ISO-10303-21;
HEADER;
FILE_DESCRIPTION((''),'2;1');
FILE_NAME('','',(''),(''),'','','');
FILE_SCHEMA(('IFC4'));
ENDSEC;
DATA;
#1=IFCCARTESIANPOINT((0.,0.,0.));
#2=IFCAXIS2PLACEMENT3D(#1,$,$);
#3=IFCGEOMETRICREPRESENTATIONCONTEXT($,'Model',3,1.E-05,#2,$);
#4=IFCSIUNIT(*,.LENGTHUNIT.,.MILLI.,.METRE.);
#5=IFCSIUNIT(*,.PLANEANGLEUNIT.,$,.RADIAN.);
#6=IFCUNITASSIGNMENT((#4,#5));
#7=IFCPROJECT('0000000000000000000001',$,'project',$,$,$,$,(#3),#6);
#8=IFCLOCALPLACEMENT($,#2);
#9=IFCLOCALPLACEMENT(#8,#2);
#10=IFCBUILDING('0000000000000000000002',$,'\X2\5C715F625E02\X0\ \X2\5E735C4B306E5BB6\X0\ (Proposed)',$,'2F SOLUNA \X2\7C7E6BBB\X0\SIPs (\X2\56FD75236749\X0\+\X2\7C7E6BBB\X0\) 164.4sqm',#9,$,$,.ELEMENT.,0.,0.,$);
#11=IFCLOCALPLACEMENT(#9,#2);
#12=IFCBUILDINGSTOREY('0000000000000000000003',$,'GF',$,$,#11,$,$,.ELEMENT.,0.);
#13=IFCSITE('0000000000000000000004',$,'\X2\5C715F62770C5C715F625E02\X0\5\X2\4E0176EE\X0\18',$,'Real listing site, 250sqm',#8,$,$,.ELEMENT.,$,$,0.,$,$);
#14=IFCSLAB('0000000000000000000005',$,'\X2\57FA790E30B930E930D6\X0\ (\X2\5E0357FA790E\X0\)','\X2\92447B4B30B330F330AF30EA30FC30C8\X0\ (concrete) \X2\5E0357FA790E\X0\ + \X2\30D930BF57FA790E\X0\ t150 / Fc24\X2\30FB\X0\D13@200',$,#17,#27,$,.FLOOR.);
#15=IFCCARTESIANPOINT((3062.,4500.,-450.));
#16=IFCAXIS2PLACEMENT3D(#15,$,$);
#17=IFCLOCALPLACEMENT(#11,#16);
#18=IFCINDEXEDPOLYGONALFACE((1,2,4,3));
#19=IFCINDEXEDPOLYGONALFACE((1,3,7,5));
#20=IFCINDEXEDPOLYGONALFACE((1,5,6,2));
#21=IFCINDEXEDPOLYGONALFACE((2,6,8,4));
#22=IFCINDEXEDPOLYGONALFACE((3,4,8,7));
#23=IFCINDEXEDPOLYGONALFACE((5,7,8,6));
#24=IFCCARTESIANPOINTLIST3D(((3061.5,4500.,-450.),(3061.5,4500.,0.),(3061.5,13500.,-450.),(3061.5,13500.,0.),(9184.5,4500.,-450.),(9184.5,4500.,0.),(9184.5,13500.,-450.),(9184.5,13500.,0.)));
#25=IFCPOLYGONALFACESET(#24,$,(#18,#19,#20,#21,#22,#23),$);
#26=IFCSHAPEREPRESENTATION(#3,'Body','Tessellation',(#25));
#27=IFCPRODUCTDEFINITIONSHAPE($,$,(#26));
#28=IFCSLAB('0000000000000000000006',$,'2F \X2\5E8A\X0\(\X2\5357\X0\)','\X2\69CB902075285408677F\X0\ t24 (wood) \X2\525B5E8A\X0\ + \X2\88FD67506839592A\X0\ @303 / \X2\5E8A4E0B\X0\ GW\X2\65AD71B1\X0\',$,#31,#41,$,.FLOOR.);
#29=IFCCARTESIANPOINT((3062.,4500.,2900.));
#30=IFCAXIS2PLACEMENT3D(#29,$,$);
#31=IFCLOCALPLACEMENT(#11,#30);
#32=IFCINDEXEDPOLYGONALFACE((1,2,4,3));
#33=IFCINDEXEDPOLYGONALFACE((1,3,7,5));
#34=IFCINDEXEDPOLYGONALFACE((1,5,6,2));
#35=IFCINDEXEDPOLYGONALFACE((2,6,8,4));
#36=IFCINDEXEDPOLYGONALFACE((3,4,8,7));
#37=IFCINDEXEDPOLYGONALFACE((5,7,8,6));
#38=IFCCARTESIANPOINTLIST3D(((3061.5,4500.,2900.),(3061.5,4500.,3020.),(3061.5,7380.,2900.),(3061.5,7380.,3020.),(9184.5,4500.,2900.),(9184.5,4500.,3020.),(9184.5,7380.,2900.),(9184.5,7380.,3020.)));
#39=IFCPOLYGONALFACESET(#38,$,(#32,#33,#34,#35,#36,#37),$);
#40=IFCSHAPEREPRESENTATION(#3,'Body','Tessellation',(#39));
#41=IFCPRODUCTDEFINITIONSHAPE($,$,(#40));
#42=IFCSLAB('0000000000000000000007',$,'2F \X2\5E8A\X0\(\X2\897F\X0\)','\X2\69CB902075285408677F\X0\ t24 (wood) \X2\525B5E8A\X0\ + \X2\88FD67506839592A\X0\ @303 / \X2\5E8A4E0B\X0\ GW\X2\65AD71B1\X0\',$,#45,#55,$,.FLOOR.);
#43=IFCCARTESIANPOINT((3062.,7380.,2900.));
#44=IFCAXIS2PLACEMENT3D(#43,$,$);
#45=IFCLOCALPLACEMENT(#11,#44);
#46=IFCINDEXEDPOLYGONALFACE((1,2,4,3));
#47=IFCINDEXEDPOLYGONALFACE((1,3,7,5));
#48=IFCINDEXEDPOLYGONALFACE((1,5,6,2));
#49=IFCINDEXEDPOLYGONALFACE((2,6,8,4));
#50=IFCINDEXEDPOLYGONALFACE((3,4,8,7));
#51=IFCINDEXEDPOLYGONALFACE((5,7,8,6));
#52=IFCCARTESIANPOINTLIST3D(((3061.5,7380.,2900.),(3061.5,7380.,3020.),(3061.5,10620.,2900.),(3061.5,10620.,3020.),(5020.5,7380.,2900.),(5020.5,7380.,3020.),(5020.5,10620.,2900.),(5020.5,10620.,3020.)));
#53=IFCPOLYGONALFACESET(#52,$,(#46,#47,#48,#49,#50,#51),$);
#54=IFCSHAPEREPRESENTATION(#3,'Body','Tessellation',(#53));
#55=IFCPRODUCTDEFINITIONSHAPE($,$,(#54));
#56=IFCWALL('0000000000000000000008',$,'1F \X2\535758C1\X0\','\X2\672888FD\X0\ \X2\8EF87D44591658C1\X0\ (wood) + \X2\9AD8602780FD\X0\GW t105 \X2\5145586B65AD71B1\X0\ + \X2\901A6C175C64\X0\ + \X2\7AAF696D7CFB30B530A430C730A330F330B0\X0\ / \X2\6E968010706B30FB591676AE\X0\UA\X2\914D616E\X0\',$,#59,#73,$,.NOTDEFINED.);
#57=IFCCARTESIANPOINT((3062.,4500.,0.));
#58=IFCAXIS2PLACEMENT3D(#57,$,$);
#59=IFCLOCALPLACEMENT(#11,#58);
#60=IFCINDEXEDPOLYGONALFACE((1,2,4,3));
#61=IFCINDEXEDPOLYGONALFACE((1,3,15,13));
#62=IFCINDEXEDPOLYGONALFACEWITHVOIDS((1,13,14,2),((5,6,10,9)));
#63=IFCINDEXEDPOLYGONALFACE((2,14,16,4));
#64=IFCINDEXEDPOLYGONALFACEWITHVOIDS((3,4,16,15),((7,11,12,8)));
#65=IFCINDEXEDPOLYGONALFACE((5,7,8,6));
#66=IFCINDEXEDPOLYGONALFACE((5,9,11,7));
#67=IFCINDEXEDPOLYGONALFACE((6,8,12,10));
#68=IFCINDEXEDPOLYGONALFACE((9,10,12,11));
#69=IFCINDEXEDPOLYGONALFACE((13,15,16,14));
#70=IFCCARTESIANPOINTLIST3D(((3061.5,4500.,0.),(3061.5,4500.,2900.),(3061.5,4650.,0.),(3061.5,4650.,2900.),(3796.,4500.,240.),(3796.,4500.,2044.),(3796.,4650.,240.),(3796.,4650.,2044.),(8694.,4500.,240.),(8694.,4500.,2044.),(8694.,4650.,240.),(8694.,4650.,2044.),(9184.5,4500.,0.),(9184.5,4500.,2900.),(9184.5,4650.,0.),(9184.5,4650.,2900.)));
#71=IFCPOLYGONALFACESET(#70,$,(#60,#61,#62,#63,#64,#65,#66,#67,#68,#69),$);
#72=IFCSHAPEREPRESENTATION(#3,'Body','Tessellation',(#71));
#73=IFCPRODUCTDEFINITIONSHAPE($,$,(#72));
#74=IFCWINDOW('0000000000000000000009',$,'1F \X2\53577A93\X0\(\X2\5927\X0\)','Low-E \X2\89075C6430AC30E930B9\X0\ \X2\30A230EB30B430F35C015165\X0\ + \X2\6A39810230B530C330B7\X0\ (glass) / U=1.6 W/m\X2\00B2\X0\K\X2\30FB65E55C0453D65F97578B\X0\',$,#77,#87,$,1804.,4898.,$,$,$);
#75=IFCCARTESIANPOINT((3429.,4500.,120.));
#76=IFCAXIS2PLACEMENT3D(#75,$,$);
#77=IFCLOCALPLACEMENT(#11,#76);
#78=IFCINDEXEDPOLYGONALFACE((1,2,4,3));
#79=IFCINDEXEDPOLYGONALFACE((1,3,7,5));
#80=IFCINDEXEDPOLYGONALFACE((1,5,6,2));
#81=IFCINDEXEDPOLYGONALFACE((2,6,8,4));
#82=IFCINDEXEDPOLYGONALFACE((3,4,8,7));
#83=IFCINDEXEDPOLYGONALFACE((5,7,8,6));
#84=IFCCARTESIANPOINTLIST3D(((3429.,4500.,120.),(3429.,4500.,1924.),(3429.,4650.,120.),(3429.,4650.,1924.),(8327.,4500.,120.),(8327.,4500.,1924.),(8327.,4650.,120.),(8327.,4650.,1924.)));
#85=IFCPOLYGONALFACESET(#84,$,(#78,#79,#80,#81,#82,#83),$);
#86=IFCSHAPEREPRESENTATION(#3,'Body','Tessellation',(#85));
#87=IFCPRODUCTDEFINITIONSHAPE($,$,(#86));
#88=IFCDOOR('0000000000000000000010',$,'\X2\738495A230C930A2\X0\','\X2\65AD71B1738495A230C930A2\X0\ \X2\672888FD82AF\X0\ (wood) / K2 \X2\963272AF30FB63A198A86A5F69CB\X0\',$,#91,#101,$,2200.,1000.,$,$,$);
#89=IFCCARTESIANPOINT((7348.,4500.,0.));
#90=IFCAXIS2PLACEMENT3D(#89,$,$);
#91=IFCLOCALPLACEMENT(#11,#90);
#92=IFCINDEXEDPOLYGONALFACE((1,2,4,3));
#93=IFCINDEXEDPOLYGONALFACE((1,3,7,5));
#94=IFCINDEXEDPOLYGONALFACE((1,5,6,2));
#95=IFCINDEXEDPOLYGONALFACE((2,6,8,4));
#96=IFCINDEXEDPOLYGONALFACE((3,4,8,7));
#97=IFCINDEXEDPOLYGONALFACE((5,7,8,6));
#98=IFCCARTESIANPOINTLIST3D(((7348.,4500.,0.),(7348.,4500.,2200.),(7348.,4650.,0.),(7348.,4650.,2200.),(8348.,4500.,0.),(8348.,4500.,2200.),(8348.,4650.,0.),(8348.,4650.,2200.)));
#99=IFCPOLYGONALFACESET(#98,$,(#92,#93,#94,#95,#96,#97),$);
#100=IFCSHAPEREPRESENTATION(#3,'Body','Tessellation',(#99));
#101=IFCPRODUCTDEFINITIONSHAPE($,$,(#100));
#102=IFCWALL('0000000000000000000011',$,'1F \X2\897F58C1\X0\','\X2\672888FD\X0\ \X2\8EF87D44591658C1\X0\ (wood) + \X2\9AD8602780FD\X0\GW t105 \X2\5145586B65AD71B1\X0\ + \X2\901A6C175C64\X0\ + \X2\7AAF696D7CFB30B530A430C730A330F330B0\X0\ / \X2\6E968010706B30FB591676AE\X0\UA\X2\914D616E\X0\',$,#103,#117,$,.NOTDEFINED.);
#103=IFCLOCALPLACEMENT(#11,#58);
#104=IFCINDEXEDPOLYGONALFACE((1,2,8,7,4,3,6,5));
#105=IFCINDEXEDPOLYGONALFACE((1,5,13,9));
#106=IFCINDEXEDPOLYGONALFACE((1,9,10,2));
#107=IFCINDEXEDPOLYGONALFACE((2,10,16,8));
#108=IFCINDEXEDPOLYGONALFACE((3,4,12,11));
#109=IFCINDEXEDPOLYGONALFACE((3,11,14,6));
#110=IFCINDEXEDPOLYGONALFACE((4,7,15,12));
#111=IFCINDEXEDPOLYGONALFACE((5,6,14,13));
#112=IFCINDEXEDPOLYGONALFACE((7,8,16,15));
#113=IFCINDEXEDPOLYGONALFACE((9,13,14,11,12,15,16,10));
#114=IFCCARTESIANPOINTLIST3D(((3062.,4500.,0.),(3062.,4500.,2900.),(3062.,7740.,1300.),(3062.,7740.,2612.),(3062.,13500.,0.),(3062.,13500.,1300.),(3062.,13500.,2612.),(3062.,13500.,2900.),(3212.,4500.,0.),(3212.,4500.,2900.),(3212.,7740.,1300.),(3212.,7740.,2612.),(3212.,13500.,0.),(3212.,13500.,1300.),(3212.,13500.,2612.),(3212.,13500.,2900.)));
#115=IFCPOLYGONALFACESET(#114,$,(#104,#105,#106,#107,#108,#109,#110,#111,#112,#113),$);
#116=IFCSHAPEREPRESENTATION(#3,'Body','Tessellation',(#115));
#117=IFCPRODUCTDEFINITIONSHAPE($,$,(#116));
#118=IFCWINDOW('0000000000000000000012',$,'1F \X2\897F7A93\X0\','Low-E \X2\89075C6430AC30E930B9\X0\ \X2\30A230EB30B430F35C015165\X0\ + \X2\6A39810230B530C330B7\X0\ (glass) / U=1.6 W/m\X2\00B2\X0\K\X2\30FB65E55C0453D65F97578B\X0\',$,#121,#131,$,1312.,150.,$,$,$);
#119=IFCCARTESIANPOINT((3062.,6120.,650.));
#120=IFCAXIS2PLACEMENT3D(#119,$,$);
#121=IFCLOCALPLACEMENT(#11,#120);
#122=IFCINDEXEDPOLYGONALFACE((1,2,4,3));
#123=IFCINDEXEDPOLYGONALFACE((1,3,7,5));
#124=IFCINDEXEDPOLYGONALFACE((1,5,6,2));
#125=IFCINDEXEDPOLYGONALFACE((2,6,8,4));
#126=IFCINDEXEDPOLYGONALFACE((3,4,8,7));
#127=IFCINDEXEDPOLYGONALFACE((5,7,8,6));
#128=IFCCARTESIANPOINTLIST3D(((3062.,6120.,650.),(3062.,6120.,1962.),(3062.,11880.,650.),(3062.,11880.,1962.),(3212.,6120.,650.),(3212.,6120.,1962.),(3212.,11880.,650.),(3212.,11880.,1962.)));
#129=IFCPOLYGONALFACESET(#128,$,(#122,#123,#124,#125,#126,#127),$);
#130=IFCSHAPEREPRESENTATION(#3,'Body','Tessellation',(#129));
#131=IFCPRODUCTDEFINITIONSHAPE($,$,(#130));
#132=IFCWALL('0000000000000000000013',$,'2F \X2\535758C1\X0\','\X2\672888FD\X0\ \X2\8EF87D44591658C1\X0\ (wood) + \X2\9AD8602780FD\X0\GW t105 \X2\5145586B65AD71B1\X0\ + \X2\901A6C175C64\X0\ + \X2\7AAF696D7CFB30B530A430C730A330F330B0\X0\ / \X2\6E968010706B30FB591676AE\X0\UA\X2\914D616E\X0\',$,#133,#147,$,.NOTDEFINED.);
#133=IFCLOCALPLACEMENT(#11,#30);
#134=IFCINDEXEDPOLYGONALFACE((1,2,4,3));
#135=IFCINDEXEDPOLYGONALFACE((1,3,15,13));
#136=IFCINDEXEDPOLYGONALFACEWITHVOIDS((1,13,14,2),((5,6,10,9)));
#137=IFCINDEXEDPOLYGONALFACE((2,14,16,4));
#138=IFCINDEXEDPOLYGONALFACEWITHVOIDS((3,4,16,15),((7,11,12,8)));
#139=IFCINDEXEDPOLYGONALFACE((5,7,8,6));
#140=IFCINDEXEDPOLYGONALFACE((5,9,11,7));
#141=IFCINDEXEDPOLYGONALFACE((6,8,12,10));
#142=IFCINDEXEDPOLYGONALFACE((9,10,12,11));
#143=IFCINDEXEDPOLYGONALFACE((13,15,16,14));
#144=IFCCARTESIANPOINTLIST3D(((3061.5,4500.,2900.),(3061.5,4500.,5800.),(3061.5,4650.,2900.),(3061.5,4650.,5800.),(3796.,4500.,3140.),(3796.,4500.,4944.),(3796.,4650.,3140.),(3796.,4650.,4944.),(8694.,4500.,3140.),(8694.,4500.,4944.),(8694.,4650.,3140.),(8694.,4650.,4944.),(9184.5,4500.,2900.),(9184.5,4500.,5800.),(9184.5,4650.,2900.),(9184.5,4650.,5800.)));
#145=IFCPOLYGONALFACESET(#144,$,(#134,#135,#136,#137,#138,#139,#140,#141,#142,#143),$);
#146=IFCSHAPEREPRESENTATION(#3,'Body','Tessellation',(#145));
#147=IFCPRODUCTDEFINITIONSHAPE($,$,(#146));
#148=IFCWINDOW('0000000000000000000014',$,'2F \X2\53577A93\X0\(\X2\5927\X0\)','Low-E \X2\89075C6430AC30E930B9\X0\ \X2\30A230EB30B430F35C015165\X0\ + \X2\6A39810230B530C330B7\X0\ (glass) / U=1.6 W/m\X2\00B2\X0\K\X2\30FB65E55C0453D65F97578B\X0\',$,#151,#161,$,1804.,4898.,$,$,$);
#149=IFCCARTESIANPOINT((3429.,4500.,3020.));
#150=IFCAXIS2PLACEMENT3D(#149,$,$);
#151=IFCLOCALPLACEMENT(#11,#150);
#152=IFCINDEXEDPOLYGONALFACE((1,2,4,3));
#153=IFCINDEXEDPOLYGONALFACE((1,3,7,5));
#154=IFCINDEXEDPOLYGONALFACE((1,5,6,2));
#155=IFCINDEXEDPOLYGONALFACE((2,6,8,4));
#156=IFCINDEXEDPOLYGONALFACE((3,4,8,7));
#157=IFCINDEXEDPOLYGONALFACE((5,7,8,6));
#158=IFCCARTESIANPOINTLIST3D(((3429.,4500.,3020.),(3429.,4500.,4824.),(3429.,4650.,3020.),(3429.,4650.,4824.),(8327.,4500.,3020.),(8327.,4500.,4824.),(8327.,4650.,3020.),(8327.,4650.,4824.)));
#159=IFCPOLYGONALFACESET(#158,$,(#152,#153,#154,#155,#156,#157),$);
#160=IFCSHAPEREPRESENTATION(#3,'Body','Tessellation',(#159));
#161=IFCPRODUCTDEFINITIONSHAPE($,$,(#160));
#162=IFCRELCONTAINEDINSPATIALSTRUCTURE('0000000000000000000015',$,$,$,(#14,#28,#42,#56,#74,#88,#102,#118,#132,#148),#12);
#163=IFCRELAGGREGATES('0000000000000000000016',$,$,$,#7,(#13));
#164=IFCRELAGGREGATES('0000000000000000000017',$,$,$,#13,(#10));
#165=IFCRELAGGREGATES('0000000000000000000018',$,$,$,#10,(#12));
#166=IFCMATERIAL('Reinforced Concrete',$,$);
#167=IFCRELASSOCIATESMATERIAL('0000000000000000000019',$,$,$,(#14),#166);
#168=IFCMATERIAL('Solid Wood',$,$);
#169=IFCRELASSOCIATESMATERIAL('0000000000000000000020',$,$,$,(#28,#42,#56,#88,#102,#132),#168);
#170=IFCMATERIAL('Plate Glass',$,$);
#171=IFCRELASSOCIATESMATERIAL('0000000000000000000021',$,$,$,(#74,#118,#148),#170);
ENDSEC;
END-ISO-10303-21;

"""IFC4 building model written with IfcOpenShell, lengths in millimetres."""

from ifc_helpers import new_model, si_unit, frame, frame_2d, origin, place, context, project, spatial, rectangle, extrude, material, element, fill, save


model = new_model("IFC4")

# Units and contexts
model_context = context("Model", 3, precision=1e-05, world=origin())
ifc_project = project(units=[si_unit("LENGTHUNIT", "METRE", prefix="MILLI"), si_unit("PLANEANGLEUNIT", "RADIAN")], contexts=[model_context])

# Site, building, storey
site_placement = place(None, origin())
site = spatial("IfcSite", under=ifc_project, at=site_placement, Name="山形県山形市5丁目18", ObjectType="Real listing site, 250sqm", CompositionType="ELEMENT", RefElevation=0.0)
building_placement = place(site_placement, origin())
building = spatial("IfcBuilding", under=site, at=building_placement, Name="山形市 平屋の家 (Proposed)", ObjectType="2F SOLUNA 籾殻SIPs (国産杉+籾殻) 164.4sqm", CompositionType="ELEMENT", ElevationOfRefHeight=0.0, ElevationOfTerrain=0.0)
storey_placement = place(building_placement, origin())
storey = spatial("IfcBuildingStorey", under=building, at=storey_placement, Name="GF", CompositionType="ELEMENT", Elevation=0.0)

# Slabs
ifc_material_1 = material(Name="Reinforced Concrete")
slab_1_placement = place(storey_placement, frame((3062.0, 4500.0, -450.0)))
element("IfcSlab", 1, at=slab_1_placement, inside=storey, material=ifc_material_1, Name="基礎スラブ (布基礎)", Description="鉄筋コンクリート (concrete) 布基礎 + ベタ基礎 t150 / Fc24・D13@200", PredefinedType="FLOOR", context=model_context, shape_type="SweptSolid", body=[
    extrude(rectangle(XDim=6123.0, YDim=9000.0, at=frame_2d((3061.0, 4500.0))), frame((3062.0, 4500.0, -450.0)), (0.0, 0.0, 1.0), 450.0),
])
ifc_material_2 = material(Name="Solid Wood")
slab_2_placement = place(storey_placement, frame((3062.0, 4500.0, 2900.0)))
element("IfcSlab", 2, at=slab_2_placement, inside=storey, material=ifc_material_2, Name="2F 床(南)", Description="構造用合板 t24 (wood) 剛床 + 製材根太 @303 / 床下 GW断熱", PredefinedType="FLOOR", context=model_context, shape_type="SweptSolid", body=[
    extrude(rectangle(XDim=6123.0, YDim=2880.0, at=frame_2d((3061.0, 1440.0))), frame((3062.0, 4500.0, 2900.0)), (0.0, 0.0, 1.0), 120.0),
])
slab_3_placement = place(storey_placement, frame((3062.0, 7380.0, 2900.0)))
element("IfcSlab", 3, at=slab_3_placement, inside=storey, material=ifc_material_2, Name="2F 床(西)", Description="構造用合板 t24 (wood) 剛床 + 製材根太 @303 / 床下 GW断熱", PredefinedType="FLOOR", context=model_context, shape_type="SweptSolid", body=[
    extrude(rectangle(XDim=1959.0, YDim=3240.0, at=frame_2d((979.0, 1620.0))), frame((3062.0, 7380.0, 2900.0)), (0.0, 0.0, 1.0), 120.0),
])

# Wall, openings, window, door
wall_1_placement = place(storey_placement, frame((3062.0, 4500.0, 0.0)))
wall_1 = element("IfcWall", 4, at=wall_1_placement, inside=storey, material=ifc_material_2, Name="1F 南壁", Description="木製 軸組外壁 (wood) + 高性能GW t105 充填断熱 + 通気層 + 窯業系サイディング / 準耐火・外皮UA配慮", PredefinedType="NOTDEFINED", context=model_context, shape_type="SweptSolid", body=[
    extrude(rectangle(XDim=6123.0, YDim=150.0, at=frame_2d((3061.0, 75.0))), frame((3062.0, 4500.0, 0.0)), (0.0, 0.0, 1.0), 2900.0),
])
opening_1_placement = place(storey_placement, frame((3429.0, 4500.0, 120.0)))
opening_1 = element("IfcOpeningElement", 5, at=opening_1_placement, cuts=wall_1, PredefinedType="NOTDEFINED", context=model_context, shape_type="SweptSolid", body=[
    extrude(rectangle(XDim=4898.0, YDim=150.0, at=frame_2d((2449.0, 75.0))), frame((3429.0, 4500.0, 120.0)), (0.0, 0.0, 1.0), 1804.0),
])
opening_2_placement = place(storey_placement, frame((7348.0, 4500.0, 0.0)))
opening_2 = element("IfcOpeningElement", 6, at=opening_2_placement, cuts=wall_1, PredefinedType="NOTDEFINED", context=model_context, shape_type="SweptSolid", body=[
    extrude(rectangle(XDim=1000.0, YDim=150.0, at=frame_2d((500.0, 75.0))), frame((7348.0, 4500.0, 0.0)), (0.0, 0.0, 1.0), 2200.0),
])
ifc_material_3 = material(Name="Plate Glass")
window_1_placement = place(storey_placement, frame((3429.0, 4500.0, 120.0)))
window_1 = element("IfcWindow", 7, at=window_1_placement, inside=storey, material=ifc_material_3, Name="1F 南窓(大)", Description="Low-E 複層ガラス アルゴン封入 + 樹脂サッシ (glass) / U=1.6 W/m²K・日射取得型", OverallHeight=1804.0, OverallWidth=4898.0, context=model_context, shape_type="SweptSolid", body=[
    extrude(rectangle(XDim=4898.0, YDim=150.0, at=frame_2d((2449.0, 75.0))), frame((3429.0, 4500.0, 120.0)), (0.0, 0.0, 1.0), 1804.0),
])
fill(opening_1, window_1)
door_placement = place(storey_placement, frame((7348.0, 4500.0, 0.0)))
door = element("IfcDoor", 8, at=door_placement, inside=storey, material=ifc_material_2, Name="玄関ドア", Description="断熱玄関ドア 木製芯 (wood) / K2 防犯・採風機構", OverallHeight=2200.0, OverallWidth=1000.0, context=model_context, shape_type="SweptSolid", body=[
    extrude(rectangle(XDim=1000.0, YDim=150.0, at=frame_2d((500.0, 75.0))), frame((7348.0, 4500.0, 0.0)), (0.0, 0.0, 1.0), 2200.0),
])
fill(opening_2, door)

# Walls, openings, windows
wall_2_placement = place(storey_placement, frame((3062.0, 4500.0, 0.0)))
wall_2 = element("IfcWall", 9, at=wall_2_placement, inside=storey, material=ifc_material_2, Name="1F 西壁", Description="木製 軸組外壁 (wood) + 高性能GW t105 充填断熱 + 通気層 + 窯業系サイディング / 準耐火・外皮UA配慮", PredefinedType="NOTDEFINED", context=model_context, shape_type="SweptSolid", body=[
    extrude(rectangle(XDim=150.0, YDim=9000.0, at=frame_2d((75.0, 4500.0))), frame((3062.0, 4500.0, 0.0)), (0.0, 0.0, 1.0), 2900.0),
])
opening_3_placement = place(storey_placement, frame((3062.0, 6120.0, 650.0)))
opening_3 = element("IfcOpeningElement", 10, at=opening_3_placement, cuts=wall_2, PredefinedType="NOTDEFINED", context=model_context, shape_type="SweptSolid", body=[
    extrude(rectangle(XDim=150.0, YDim=5760.0, at=frame_2d((75.0, 2880.0))), frame((3062.0, 6120.0, 650.0)), (0.0, 0.0, 1.0), 1312.0),
])
window_2_placement = place(storey_placement, frame((3062.0, 6120.0, 650.0)))
window_2 = element("IfcWindow", 11, at=window_2_placement, inside=storey, material=ifc_material_3, Name="1F 西窓", Description="Low-E 複層ガラス アルゴン封入 + 樹脂サッシ (glass) / U=1.6 W/m²K・日射取得型", OverallHeight=1312.0, OverallWidth=150.0, context=model_context, shape_type="SweptSolid", body=[
    extrude(rectangle(XDim=150.0, YDim=5760.0, at=frame_2d((75.0, 2880.0))), frame((3062.0, 6120.0, 650.0)), (0.0, 0.0, 1.0), 1312.0),
])
fill(opening_3, window_2)
wall_3_placement = place(storey_placement, frame((3062.0, 4500.0, 2900.0)))
wall_3 = element("IfcWall", 12, at=wall_3_placement, inside=storey, material=ifc_material_2, Name="2F 南壁", Description="木製 軸組外壁 (wood) + 高性能GW t105 充填断熱 + 通気層 + 窯業系サイディング / 準耐火・外皮UA配慮", PredefinedType="NOTDEFINED", context=model_context, shape_type="SweptSolid", body=[
    extrude(rectangle(XDim=6123.0, YDim=150.0, at=frame_2d((3061.0, 75.0))), frame((3062.0, 4500.0, 2900.0)), (0.0, 0.0, 1.0), 2900.0),
])
opening_4_placement = place(storey_placement, frame((3429.0, 4500.0, 3020.0)))
opening_4 = element("IfcOpeningElement", 13, at=opening_4_placement, cuts=wall_3, PredefinedType="NOTDEFINED", context=model_context, shape_type="SweptSolid", body=[
    extrude(rectangle(XDim=4898.0, YDim=150.0, at=frame_2d((2449.0, 75.0))), frame((3429.0, 4500.0, 3020.0)), (0.0, 0.0, 1.0), 1804.0),
])
window_3_placement = place(storey_placement, frame((3429.0, 4500.0, 3020.0)))
window_3 = element("IfcWindow", 14, at=window_3_placement, inside=storey, material=ifc_material_3, Name="2F 南窓(大)", Description="Low-E 複層ガラス アルゴン封入 + 樹脂サッシ (glass) / U=1.6 W/m²K・日射取得型", OverallHeight=1804.0, OverallWidth=4898.0, context=model_context, shape_type="SweptSolid", body=[
    extrude(rectangle(XDim=4898.0, YDim=150.0, at=frame_2d((2449.0, 75.0))), frame((3429.0, 4500.0, 3020.0)), (0.0, 0.0, 1.0), 1804.0),
])
fill(opening_4, window_3)

save(model, "model.ifc")
